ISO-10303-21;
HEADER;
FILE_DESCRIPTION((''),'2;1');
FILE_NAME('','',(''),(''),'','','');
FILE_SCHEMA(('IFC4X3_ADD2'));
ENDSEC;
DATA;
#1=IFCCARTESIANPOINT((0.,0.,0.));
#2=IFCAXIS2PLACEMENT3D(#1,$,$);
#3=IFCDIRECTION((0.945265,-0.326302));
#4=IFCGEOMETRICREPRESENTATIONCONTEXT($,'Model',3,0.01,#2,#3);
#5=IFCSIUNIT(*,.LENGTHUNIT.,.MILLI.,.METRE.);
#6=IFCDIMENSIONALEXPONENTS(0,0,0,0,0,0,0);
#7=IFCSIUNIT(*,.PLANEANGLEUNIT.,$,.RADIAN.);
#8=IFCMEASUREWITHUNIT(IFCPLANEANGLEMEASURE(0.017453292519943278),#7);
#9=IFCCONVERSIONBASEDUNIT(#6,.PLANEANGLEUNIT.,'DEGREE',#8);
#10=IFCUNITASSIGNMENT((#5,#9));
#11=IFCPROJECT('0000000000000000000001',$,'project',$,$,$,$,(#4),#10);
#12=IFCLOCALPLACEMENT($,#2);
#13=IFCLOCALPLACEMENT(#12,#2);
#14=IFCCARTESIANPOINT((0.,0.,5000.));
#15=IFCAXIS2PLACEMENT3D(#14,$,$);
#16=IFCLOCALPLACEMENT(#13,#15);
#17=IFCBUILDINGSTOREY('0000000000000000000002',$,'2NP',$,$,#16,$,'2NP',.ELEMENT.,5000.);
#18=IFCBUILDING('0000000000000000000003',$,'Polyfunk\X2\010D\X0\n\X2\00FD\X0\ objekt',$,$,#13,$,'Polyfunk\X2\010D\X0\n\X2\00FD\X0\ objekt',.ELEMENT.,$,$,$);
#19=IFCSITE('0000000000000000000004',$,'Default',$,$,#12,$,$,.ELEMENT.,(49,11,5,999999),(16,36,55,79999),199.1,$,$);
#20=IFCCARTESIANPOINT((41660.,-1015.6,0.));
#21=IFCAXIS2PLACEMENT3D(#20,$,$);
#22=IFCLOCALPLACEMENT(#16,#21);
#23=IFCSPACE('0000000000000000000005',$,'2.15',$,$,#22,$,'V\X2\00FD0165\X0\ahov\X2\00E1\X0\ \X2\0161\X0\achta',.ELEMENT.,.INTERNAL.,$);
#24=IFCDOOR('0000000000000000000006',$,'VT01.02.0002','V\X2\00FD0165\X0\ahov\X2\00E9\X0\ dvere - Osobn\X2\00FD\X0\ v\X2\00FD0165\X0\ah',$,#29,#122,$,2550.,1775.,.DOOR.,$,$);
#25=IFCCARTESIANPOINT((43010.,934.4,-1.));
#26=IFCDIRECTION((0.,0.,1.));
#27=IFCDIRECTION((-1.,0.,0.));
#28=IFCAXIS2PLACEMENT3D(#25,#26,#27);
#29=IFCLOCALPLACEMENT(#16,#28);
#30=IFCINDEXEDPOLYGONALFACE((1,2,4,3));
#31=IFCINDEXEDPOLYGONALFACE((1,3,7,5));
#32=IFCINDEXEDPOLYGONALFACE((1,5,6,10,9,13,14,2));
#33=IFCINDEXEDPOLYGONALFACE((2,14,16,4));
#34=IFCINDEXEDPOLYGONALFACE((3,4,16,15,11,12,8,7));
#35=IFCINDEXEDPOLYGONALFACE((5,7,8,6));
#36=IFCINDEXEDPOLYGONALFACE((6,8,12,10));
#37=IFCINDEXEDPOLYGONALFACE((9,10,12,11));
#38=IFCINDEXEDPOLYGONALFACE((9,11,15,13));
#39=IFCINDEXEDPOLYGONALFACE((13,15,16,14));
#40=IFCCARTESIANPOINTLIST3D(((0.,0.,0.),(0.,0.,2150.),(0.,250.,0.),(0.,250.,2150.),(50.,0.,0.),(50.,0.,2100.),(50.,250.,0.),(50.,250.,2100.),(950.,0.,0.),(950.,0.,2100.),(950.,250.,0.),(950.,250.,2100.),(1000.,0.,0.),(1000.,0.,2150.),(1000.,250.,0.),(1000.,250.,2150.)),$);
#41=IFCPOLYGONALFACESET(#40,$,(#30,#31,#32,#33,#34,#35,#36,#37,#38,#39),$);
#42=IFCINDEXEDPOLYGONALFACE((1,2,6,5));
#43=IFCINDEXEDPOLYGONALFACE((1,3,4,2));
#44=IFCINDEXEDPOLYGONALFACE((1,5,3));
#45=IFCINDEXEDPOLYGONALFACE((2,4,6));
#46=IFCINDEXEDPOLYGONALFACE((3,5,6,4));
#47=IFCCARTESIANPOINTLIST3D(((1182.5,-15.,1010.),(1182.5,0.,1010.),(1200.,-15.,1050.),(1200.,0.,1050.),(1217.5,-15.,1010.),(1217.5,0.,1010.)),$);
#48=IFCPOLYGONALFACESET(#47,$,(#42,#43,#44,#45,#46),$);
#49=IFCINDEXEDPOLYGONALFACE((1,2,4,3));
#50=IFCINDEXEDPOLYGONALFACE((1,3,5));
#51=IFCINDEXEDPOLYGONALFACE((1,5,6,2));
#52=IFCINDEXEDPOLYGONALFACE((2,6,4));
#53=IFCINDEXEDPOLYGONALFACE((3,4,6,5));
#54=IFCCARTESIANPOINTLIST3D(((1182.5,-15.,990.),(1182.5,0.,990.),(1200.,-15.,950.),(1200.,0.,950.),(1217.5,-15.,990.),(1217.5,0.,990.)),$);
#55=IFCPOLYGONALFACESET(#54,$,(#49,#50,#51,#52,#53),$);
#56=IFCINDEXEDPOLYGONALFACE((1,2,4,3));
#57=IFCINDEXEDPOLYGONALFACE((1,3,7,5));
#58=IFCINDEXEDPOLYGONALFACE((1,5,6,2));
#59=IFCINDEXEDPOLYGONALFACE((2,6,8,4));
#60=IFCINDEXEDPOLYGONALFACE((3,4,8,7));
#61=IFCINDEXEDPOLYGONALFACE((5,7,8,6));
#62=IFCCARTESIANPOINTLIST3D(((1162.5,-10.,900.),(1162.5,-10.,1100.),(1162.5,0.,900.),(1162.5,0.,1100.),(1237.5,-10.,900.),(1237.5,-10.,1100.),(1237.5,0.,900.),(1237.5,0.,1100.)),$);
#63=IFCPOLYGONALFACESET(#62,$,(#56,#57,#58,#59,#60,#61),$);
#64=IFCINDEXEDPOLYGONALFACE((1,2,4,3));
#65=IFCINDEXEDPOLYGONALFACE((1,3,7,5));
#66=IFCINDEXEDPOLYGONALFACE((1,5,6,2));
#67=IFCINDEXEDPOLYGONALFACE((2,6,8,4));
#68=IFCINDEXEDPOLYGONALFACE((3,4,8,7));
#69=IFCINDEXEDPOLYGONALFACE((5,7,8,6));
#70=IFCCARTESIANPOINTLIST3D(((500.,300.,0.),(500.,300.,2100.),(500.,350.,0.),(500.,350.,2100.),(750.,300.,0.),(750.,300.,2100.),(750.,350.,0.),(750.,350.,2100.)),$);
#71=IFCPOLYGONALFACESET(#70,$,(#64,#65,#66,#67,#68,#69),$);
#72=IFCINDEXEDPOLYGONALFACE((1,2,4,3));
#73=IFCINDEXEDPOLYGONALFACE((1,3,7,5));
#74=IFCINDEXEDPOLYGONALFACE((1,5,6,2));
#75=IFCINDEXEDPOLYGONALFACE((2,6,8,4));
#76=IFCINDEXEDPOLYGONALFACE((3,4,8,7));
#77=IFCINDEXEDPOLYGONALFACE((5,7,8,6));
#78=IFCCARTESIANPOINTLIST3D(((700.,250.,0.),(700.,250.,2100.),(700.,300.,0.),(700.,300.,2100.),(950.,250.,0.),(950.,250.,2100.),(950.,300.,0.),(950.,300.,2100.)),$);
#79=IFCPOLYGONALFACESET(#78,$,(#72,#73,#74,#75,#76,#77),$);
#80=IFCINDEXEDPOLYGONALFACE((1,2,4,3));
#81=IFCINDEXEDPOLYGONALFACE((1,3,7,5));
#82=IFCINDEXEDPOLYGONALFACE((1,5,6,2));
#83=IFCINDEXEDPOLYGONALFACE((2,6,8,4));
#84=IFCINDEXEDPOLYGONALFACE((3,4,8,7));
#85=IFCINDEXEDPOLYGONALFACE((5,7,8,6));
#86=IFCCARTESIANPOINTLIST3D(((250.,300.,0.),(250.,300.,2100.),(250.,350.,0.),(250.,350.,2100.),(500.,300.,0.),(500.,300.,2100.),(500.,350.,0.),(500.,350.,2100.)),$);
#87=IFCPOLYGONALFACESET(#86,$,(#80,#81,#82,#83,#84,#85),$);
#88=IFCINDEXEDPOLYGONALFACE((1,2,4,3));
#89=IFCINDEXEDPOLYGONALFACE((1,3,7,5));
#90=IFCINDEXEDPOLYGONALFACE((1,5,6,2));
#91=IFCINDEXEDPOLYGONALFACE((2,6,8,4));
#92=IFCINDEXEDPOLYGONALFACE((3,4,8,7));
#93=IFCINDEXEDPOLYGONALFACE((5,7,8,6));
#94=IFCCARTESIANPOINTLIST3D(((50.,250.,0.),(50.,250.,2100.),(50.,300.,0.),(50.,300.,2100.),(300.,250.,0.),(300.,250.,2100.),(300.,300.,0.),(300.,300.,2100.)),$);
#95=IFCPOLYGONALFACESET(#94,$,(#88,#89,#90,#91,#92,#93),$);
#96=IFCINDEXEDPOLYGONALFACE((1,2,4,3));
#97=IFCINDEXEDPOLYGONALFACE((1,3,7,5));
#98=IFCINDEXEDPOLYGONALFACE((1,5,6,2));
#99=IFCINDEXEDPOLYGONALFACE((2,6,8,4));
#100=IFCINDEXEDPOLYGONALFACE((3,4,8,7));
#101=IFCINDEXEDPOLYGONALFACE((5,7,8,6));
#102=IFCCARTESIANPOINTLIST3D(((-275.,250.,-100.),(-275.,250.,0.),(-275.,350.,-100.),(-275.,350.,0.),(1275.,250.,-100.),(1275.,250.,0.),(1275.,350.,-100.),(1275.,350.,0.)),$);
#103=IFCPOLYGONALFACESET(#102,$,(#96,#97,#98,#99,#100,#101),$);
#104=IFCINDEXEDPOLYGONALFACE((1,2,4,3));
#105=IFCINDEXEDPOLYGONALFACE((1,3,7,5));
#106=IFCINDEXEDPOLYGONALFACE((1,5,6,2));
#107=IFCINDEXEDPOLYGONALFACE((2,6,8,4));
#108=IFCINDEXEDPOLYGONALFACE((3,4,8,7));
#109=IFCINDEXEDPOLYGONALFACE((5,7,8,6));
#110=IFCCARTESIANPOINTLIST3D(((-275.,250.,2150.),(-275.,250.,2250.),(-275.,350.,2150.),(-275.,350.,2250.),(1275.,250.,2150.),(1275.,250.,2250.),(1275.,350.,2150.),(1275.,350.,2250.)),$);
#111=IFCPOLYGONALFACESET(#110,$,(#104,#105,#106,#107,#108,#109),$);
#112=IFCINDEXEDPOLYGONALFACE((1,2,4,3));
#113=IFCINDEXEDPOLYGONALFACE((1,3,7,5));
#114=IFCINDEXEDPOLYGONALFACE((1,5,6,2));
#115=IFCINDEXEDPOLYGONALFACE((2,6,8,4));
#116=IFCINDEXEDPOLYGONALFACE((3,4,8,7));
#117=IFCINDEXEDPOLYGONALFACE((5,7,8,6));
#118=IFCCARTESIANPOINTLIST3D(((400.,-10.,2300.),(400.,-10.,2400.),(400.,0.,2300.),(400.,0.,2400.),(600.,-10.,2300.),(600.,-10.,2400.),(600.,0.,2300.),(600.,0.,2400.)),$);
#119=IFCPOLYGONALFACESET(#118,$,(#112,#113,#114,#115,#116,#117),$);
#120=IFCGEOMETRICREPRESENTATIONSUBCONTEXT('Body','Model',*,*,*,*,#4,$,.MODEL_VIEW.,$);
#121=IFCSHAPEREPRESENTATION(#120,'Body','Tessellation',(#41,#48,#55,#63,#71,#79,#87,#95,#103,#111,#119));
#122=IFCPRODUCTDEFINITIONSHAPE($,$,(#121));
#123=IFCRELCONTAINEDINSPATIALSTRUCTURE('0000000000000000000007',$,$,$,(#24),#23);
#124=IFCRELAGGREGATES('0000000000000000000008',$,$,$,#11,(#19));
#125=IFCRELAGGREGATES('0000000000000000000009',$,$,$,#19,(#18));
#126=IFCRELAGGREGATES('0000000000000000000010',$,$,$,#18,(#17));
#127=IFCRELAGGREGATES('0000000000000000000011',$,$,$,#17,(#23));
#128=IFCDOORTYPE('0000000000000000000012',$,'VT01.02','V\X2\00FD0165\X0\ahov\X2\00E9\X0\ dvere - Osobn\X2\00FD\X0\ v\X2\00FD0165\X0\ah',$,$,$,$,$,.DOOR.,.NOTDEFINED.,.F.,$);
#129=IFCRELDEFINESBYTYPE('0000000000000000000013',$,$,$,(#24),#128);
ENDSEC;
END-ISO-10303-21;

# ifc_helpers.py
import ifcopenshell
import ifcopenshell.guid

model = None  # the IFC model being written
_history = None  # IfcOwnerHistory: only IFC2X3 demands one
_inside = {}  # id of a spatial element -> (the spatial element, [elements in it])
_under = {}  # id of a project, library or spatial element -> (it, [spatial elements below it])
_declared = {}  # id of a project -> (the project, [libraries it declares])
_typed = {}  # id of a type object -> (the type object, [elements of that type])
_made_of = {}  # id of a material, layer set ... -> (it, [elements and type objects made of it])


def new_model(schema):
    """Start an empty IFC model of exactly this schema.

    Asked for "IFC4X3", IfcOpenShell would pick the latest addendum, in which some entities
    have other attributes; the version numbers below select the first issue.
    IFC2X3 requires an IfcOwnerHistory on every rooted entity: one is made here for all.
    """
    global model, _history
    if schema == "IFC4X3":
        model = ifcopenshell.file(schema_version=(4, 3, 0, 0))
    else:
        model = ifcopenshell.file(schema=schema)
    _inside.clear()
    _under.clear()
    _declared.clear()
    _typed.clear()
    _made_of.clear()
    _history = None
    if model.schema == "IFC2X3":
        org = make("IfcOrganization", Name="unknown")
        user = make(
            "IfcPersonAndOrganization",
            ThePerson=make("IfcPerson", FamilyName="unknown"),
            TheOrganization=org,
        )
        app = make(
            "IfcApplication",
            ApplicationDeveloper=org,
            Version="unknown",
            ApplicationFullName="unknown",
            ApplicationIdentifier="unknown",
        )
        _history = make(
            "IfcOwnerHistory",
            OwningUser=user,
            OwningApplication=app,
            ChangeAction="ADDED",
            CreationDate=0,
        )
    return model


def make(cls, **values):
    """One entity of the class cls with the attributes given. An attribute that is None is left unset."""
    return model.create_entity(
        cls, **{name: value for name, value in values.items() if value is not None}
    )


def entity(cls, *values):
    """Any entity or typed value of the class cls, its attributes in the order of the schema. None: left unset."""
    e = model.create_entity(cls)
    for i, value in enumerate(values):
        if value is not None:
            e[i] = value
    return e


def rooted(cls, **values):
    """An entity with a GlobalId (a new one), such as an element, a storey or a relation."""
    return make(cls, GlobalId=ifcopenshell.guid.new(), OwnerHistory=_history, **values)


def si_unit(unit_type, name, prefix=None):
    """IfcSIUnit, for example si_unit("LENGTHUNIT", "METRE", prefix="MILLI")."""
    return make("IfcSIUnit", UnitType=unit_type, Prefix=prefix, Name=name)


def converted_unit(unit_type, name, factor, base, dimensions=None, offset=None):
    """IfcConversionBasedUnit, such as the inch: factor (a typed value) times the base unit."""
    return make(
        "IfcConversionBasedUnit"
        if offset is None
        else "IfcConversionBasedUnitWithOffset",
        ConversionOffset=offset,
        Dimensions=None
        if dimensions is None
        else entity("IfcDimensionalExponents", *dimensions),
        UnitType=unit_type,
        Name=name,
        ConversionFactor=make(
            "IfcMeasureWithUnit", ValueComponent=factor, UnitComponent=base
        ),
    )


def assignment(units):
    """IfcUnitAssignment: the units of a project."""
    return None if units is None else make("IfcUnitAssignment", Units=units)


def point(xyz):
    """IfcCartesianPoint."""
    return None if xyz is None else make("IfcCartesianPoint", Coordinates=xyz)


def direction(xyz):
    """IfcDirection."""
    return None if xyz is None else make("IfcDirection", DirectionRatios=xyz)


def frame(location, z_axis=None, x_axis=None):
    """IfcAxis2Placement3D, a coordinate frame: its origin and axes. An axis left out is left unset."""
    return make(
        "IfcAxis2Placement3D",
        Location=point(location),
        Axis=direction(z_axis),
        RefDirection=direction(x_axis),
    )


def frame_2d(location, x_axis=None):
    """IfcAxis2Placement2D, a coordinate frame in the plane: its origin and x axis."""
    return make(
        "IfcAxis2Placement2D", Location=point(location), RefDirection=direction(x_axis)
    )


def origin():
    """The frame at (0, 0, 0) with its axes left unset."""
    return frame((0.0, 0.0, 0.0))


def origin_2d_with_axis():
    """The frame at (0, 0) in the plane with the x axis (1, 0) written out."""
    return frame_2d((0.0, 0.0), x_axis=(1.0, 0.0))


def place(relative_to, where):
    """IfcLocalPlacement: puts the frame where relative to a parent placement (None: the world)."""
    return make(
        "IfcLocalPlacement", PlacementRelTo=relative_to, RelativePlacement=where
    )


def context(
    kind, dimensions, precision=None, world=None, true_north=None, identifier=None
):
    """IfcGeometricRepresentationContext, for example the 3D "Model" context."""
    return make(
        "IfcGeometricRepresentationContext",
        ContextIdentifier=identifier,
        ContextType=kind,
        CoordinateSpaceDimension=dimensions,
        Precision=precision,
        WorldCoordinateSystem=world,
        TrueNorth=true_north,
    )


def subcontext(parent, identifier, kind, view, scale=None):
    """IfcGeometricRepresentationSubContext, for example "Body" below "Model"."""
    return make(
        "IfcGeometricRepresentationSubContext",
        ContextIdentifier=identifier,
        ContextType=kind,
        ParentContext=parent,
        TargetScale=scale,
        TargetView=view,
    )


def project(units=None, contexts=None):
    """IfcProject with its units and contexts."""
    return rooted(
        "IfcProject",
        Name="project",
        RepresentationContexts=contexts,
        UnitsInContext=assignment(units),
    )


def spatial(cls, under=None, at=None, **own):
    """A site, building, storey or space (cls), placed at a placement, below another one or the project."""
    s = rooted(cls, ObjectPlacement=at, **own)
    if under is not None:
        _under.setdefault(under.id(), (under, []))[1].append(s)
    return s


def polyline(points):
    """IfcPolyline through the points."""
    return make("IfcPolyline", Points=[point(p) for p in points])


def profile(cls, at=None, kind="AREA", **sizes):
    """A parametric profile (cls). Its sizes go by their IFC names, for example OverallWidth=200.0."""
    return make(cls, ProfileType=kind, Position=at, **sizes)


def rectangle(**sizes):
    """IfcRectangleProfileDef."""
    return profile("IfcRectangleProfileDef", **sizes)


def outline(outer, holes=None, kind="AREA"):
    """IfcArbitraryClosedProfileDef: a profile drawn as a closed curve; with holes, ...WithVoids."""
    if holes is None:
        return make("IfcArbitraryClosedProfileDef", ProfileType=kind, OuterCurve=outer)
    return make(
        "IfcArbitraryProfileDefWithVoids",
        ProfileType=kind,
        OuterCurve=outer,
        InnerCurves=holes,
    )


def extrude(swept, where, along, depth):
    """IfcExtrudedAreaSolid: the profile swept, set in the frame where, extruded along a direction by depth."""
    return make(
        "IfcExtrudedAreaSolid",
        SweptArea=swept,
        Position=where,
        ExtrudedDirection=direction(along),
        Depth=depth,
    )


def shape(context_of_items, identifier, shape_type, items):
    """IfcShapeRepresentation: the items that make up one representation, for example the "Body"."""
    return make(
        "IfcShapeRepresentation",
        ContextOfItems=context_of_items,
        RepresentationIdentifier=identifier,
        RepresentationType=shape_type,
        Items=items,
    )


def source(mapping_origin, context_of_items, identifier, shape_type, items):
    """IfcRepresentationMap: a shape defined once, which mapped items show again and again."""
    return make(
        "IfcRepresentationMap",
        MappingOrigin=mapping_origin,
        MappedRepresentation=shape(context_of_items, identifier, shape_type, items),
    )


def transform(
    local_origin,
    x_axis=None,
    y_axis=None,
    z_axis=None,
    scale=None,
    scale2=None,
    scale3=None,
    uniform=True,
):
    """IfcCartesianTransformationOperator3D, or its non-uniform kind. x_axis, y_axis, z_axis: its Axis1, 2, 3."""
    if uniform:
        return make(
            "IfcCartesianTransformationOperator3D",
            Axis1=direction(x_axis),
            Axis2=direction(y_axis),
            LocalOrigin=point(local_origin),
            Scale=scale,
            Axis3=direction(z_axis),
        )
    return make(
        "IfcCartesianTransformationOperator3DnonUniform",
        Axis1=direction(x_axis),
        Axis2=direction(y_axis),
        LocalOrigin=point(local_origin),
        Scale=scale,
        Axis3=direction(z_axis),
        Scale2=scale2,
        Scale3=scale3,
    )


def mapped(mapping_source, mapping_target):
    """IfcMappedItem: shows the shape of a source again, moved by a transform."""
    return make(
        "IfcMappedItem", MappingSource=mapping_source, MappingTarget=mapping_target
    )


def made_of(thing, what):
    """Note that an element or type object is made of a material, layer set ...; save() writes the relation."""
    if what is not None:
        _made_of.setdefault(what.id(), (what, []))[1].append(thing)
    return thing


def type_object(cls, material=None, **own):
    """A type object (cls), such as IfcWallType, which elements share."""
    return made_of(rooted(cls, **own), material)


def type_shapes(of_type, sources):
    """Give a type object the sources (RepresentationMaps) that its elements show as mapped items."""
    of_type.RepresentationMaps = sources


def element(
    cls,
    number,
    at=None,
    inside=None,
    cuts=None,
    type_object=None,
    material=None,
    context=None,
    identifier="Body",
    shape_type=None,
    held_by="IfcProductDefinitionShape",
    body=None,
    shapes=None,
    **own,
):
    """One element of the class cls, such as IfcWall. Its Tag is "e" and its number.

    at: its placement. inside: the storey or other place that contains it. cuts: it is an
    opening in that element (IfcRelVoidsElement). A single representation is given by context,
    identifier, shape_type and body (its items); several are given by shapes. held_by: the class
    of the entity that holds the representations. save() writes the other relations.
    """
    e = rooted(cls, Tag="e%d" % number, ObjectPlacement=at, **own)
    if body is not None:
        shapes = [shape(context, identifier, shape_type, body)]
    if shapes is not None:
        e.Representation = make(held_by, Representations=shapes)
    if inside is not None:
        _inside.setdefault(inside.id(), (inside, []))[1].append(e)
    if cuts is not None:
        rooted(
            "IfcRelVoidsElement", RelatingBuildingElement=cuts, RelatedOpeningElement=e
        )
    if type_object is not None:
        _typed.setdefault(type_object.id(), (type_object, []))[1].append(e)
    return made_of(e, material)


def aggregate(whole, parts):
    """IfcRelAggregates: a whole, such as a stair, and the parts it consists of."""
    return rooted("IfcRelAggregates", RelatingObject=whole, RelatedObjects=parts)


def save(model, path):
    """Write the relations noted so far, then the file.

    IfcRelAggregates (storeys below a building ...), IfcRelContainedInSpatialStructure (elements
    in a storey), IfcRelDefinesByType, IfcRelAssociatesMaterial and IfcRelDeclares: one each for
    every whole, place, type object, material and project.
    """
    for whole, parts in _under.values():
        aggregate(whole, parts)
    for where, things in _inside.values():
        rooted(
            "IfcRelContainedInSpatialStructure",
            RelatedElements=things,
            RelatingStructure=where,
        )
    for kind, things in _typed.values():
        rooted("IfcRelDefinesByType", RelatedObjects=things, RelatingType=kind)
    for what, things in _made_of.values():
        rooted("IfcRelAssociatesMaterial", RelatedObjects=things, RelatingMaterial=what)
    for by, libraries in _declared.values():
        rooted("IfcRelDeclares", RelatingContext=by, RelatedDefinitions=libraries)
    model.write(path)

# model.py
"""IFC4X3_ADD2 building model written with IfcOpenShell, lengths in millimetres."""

from ifc_helpers import new_model, entity, si_unit, converted_unit, direction, frame, frame_2d, origin, origin_2d_with_axis, place, context, subcontext, project, spatial, polyline, rectangle, outline, extrude, source, transform, mapped, type_object, type_shapes, element, save


model = new_model("IFC4X3_ADD2")

# Units and contexts
model_context = context("Model", 3, precision=0.01, world=origin(), true_north=direction((0.945265, -0.326302)))
body_context = subcontext(model_context, "Body", "Model", "MODEL_VIEW")
ifc_project = project(units=[si_unit("LENGTHUNIT", "METRE", prefix="MILLI"), converted_unit("PLANEANGLEUNIT", "DEGREE", entity("IfcPlaneAngleMeasure", 0.017453292519943278), si_unit("PLANEANGLEUNIT", "RADIAN"), dimensions=[0, 0, 0, 0, 0, 0, 0])], contexts=[model_context])

# Site, building, storey
site_placement = place(None, origin())
site = spatial("IfcSite", under=ifc_project, at=site_placement, Name="Default", CompositionType="ELEMENT", RefLatitude=(49, 11, 5, 999999), RefLongitude=(16, 36, 55, 79999), RefElevation=199.1)
building_placement = place(site_placement, origin())
building = spatial("IfcBuilding", under=site, at=building_placement, Name="Polyfunkčný objekt", LongName="Polyfunkčný objekt", CompositionType="ELEMENT")
storey_placement = place(building_placement, frame((0.0, 0.0, 5000.0)))
storey = spatial("IfcBuildingStorey", under=building, at=storey_placement, Name="2NP", LongName="2NP", CompositionType="ELEMENT", Elevation=5000.0)

# Shared definitions
space_1_placement = place(storey_placement, frame((41660.0, -1015.6, 0.0)))
space_1 = spatial("IfcSpace", under=storey, at=space_1_placement, Name="2.15", LongName="Výťahová šachta", CompositionType="ELEMENT", PredefinedType="INTERNAL")

# Door
door_type_1 = type_object("IfcDoorType", Name="VT01.02", Description="Výťahové dvere - Osobný výťah", OperationType="NOTDEFINED", ParameterTakesPrecedence=False, PredefinedType="DOOR")
shared_shape_1 = source(origin(), body_context, "Body", "SweptSolid", [
    extrude(outline(polyline([(-1087.5, -500.0), (1062.5, -500.0), (1062.5, -450.0), (-1037.5, -450.0), (-1037.5, 450.0), (1062.5, 450.0), (1062.5, 500.0), (-1087.5, 500.0), (-1087.5, -500.0)])), frame((500.0, 0.0, 1062.5), z_axis=(0.0, 1.0, 0.0), x_axis=(0.0, 0.0, -1.0)), (0.0, 0.0, 1.0), 250.0),
    extrude(outline(polyline([(-24.4, -10.7), (19.2, -10.7), (5.2, 21.4), (-24.4, -10.7)])), frame((1200.0, -15.0, 1023.3), z_axis=(0.0, 1.0, 0.0), x_axis=(0.400819, 0.0, -0.916157)), (0.0, 0.0, 1.0), 15.0),
    extrude(outline(polyline([(-24.4, -10.7), (19.2, -10.7), (5.2, 21.4), (-24.4, -10.7)])), frame((1200.0, -15.0, 976.7), z_axis=(0.0, 1.0, 0.0), x_axis=(-0.400819, 0.0, 0.916157)), (0.0, 0.0, 1.0), 15.0),
    extrude(rectangle(XDim=10.0, YDim=75.0, at=frame_2d((0.0, 0.0), x_axis=(1.0, 0.0))), frame((1200.0, -5.0, 900.0), z_axis=(0.0, 0.0, 1.0), x_axis=(0.0, 1.0, 0.0)), (0.0, 0.0, 1.0), 200.0),
    extrude(rectangle(XDim=50.0, YDim=250.0, at=origin_2d_with_axis()), frame((625.0, 325.0, 0.0), z_axis=(0.0, 0.0, 1.0), x_axis=(0.0, -1.0, 0.0)), (0.0, 0.0, 1.0), 2100.0),
    extrude(rectangle(XDim=50.0, YDim=250.0, at=frame_2d((0.0, 0.0), x_axis=(1.0, 0.0))), frame((825.0, 275.0, 0.0), z_axis=(0.0, 0.0, 1.0), x_axis=(0.0, -1.0, 0.0)), (0.0, 0.0, 1.0), 2100.0),
    extrude(rectangle(XDim=250.0, YDim=50.0, at=frame_2d((0.0, 0.0), x_axis=(1.0, 0.0))), frame((375.0, 325.0, 0.0), z_axis=(0.0, 0.0, 1.0), x_axis=(-1.0, 0.0, 0.0)), (0.0, 0.0, 1.0), 2100.0),
    extrude(rectangle(XDim=250.0, YDim=50.0, at=frame_2d((0.0, 0.0), x_axis=(1.0, 0.0))), frame((175.0, 275.0, 0.0), z_axis=(0.0, 0.0, 1.0), x_axis=(-1.0, 0.0, 0.0)), (0.0, 0.0, 1.0), 2100.0),
    extrude(rectangle(XDim=1550.0, YDim=100.0, at=frame_2d((0.0, 0.0), x_axis=(1.0, 0.0))), frame((500.0, 300.0, -100.0), z_axis=(0.0, 0.0, 1.0), x_axis=(-1.0, 0.0, 0.0)), (0.0, 0.0, 1.0), 100.0),
    extrude(rectangle(XDim=1550.0, YDim=100.0, at=frame_2d((0.0, 0.0), x_axis=(1.0, 0.0))), frame((500.0, 300.0, 2150.0), z_axis=(0.0, 0.0, 1.0), x_axis=(-1.0, 0.0, 0.0)), (0.0, 0.0, 1.0), 100.0),
    extrude(rectangle(XDim=10.0, YDim=200.0, at=frame_2d((0.0, 0.0), x_axis=(1.0, 0.0))), frame((500.0, -5.0, 2300.0), z_axis=(0.0, 0.0, 1.0), x_axis=(0.0, 1.0, 0.0)), (0.0, 0.0, 1.0), 100.0),
])
type_shapes(door_type_1, [shared_shape_1])
door_1_placement = place(storey_placement, frame((43010.0, 934.4, -1.0), z_axis=(0.0, 0.0, 1.0), x_axis=(-1.0, 0.0, 0.0)))
element("IfcDoor", 1, at=door_1_placement, inside=space_1, type_object=door_type_1, Name="VT01.02.0002", Description="Výťahové dvere - Osobný výťah", OverallHeight=2550.0, OverallWidth=1775.0, PredefinedType="DOOR", context=body_context, shape_type="MappedRepresentation", body=[
    mapped(shared_shape_1, transform((0.0, 0.0, 0.0), scale=1.0)),
])

save(model, "model.ifc")
